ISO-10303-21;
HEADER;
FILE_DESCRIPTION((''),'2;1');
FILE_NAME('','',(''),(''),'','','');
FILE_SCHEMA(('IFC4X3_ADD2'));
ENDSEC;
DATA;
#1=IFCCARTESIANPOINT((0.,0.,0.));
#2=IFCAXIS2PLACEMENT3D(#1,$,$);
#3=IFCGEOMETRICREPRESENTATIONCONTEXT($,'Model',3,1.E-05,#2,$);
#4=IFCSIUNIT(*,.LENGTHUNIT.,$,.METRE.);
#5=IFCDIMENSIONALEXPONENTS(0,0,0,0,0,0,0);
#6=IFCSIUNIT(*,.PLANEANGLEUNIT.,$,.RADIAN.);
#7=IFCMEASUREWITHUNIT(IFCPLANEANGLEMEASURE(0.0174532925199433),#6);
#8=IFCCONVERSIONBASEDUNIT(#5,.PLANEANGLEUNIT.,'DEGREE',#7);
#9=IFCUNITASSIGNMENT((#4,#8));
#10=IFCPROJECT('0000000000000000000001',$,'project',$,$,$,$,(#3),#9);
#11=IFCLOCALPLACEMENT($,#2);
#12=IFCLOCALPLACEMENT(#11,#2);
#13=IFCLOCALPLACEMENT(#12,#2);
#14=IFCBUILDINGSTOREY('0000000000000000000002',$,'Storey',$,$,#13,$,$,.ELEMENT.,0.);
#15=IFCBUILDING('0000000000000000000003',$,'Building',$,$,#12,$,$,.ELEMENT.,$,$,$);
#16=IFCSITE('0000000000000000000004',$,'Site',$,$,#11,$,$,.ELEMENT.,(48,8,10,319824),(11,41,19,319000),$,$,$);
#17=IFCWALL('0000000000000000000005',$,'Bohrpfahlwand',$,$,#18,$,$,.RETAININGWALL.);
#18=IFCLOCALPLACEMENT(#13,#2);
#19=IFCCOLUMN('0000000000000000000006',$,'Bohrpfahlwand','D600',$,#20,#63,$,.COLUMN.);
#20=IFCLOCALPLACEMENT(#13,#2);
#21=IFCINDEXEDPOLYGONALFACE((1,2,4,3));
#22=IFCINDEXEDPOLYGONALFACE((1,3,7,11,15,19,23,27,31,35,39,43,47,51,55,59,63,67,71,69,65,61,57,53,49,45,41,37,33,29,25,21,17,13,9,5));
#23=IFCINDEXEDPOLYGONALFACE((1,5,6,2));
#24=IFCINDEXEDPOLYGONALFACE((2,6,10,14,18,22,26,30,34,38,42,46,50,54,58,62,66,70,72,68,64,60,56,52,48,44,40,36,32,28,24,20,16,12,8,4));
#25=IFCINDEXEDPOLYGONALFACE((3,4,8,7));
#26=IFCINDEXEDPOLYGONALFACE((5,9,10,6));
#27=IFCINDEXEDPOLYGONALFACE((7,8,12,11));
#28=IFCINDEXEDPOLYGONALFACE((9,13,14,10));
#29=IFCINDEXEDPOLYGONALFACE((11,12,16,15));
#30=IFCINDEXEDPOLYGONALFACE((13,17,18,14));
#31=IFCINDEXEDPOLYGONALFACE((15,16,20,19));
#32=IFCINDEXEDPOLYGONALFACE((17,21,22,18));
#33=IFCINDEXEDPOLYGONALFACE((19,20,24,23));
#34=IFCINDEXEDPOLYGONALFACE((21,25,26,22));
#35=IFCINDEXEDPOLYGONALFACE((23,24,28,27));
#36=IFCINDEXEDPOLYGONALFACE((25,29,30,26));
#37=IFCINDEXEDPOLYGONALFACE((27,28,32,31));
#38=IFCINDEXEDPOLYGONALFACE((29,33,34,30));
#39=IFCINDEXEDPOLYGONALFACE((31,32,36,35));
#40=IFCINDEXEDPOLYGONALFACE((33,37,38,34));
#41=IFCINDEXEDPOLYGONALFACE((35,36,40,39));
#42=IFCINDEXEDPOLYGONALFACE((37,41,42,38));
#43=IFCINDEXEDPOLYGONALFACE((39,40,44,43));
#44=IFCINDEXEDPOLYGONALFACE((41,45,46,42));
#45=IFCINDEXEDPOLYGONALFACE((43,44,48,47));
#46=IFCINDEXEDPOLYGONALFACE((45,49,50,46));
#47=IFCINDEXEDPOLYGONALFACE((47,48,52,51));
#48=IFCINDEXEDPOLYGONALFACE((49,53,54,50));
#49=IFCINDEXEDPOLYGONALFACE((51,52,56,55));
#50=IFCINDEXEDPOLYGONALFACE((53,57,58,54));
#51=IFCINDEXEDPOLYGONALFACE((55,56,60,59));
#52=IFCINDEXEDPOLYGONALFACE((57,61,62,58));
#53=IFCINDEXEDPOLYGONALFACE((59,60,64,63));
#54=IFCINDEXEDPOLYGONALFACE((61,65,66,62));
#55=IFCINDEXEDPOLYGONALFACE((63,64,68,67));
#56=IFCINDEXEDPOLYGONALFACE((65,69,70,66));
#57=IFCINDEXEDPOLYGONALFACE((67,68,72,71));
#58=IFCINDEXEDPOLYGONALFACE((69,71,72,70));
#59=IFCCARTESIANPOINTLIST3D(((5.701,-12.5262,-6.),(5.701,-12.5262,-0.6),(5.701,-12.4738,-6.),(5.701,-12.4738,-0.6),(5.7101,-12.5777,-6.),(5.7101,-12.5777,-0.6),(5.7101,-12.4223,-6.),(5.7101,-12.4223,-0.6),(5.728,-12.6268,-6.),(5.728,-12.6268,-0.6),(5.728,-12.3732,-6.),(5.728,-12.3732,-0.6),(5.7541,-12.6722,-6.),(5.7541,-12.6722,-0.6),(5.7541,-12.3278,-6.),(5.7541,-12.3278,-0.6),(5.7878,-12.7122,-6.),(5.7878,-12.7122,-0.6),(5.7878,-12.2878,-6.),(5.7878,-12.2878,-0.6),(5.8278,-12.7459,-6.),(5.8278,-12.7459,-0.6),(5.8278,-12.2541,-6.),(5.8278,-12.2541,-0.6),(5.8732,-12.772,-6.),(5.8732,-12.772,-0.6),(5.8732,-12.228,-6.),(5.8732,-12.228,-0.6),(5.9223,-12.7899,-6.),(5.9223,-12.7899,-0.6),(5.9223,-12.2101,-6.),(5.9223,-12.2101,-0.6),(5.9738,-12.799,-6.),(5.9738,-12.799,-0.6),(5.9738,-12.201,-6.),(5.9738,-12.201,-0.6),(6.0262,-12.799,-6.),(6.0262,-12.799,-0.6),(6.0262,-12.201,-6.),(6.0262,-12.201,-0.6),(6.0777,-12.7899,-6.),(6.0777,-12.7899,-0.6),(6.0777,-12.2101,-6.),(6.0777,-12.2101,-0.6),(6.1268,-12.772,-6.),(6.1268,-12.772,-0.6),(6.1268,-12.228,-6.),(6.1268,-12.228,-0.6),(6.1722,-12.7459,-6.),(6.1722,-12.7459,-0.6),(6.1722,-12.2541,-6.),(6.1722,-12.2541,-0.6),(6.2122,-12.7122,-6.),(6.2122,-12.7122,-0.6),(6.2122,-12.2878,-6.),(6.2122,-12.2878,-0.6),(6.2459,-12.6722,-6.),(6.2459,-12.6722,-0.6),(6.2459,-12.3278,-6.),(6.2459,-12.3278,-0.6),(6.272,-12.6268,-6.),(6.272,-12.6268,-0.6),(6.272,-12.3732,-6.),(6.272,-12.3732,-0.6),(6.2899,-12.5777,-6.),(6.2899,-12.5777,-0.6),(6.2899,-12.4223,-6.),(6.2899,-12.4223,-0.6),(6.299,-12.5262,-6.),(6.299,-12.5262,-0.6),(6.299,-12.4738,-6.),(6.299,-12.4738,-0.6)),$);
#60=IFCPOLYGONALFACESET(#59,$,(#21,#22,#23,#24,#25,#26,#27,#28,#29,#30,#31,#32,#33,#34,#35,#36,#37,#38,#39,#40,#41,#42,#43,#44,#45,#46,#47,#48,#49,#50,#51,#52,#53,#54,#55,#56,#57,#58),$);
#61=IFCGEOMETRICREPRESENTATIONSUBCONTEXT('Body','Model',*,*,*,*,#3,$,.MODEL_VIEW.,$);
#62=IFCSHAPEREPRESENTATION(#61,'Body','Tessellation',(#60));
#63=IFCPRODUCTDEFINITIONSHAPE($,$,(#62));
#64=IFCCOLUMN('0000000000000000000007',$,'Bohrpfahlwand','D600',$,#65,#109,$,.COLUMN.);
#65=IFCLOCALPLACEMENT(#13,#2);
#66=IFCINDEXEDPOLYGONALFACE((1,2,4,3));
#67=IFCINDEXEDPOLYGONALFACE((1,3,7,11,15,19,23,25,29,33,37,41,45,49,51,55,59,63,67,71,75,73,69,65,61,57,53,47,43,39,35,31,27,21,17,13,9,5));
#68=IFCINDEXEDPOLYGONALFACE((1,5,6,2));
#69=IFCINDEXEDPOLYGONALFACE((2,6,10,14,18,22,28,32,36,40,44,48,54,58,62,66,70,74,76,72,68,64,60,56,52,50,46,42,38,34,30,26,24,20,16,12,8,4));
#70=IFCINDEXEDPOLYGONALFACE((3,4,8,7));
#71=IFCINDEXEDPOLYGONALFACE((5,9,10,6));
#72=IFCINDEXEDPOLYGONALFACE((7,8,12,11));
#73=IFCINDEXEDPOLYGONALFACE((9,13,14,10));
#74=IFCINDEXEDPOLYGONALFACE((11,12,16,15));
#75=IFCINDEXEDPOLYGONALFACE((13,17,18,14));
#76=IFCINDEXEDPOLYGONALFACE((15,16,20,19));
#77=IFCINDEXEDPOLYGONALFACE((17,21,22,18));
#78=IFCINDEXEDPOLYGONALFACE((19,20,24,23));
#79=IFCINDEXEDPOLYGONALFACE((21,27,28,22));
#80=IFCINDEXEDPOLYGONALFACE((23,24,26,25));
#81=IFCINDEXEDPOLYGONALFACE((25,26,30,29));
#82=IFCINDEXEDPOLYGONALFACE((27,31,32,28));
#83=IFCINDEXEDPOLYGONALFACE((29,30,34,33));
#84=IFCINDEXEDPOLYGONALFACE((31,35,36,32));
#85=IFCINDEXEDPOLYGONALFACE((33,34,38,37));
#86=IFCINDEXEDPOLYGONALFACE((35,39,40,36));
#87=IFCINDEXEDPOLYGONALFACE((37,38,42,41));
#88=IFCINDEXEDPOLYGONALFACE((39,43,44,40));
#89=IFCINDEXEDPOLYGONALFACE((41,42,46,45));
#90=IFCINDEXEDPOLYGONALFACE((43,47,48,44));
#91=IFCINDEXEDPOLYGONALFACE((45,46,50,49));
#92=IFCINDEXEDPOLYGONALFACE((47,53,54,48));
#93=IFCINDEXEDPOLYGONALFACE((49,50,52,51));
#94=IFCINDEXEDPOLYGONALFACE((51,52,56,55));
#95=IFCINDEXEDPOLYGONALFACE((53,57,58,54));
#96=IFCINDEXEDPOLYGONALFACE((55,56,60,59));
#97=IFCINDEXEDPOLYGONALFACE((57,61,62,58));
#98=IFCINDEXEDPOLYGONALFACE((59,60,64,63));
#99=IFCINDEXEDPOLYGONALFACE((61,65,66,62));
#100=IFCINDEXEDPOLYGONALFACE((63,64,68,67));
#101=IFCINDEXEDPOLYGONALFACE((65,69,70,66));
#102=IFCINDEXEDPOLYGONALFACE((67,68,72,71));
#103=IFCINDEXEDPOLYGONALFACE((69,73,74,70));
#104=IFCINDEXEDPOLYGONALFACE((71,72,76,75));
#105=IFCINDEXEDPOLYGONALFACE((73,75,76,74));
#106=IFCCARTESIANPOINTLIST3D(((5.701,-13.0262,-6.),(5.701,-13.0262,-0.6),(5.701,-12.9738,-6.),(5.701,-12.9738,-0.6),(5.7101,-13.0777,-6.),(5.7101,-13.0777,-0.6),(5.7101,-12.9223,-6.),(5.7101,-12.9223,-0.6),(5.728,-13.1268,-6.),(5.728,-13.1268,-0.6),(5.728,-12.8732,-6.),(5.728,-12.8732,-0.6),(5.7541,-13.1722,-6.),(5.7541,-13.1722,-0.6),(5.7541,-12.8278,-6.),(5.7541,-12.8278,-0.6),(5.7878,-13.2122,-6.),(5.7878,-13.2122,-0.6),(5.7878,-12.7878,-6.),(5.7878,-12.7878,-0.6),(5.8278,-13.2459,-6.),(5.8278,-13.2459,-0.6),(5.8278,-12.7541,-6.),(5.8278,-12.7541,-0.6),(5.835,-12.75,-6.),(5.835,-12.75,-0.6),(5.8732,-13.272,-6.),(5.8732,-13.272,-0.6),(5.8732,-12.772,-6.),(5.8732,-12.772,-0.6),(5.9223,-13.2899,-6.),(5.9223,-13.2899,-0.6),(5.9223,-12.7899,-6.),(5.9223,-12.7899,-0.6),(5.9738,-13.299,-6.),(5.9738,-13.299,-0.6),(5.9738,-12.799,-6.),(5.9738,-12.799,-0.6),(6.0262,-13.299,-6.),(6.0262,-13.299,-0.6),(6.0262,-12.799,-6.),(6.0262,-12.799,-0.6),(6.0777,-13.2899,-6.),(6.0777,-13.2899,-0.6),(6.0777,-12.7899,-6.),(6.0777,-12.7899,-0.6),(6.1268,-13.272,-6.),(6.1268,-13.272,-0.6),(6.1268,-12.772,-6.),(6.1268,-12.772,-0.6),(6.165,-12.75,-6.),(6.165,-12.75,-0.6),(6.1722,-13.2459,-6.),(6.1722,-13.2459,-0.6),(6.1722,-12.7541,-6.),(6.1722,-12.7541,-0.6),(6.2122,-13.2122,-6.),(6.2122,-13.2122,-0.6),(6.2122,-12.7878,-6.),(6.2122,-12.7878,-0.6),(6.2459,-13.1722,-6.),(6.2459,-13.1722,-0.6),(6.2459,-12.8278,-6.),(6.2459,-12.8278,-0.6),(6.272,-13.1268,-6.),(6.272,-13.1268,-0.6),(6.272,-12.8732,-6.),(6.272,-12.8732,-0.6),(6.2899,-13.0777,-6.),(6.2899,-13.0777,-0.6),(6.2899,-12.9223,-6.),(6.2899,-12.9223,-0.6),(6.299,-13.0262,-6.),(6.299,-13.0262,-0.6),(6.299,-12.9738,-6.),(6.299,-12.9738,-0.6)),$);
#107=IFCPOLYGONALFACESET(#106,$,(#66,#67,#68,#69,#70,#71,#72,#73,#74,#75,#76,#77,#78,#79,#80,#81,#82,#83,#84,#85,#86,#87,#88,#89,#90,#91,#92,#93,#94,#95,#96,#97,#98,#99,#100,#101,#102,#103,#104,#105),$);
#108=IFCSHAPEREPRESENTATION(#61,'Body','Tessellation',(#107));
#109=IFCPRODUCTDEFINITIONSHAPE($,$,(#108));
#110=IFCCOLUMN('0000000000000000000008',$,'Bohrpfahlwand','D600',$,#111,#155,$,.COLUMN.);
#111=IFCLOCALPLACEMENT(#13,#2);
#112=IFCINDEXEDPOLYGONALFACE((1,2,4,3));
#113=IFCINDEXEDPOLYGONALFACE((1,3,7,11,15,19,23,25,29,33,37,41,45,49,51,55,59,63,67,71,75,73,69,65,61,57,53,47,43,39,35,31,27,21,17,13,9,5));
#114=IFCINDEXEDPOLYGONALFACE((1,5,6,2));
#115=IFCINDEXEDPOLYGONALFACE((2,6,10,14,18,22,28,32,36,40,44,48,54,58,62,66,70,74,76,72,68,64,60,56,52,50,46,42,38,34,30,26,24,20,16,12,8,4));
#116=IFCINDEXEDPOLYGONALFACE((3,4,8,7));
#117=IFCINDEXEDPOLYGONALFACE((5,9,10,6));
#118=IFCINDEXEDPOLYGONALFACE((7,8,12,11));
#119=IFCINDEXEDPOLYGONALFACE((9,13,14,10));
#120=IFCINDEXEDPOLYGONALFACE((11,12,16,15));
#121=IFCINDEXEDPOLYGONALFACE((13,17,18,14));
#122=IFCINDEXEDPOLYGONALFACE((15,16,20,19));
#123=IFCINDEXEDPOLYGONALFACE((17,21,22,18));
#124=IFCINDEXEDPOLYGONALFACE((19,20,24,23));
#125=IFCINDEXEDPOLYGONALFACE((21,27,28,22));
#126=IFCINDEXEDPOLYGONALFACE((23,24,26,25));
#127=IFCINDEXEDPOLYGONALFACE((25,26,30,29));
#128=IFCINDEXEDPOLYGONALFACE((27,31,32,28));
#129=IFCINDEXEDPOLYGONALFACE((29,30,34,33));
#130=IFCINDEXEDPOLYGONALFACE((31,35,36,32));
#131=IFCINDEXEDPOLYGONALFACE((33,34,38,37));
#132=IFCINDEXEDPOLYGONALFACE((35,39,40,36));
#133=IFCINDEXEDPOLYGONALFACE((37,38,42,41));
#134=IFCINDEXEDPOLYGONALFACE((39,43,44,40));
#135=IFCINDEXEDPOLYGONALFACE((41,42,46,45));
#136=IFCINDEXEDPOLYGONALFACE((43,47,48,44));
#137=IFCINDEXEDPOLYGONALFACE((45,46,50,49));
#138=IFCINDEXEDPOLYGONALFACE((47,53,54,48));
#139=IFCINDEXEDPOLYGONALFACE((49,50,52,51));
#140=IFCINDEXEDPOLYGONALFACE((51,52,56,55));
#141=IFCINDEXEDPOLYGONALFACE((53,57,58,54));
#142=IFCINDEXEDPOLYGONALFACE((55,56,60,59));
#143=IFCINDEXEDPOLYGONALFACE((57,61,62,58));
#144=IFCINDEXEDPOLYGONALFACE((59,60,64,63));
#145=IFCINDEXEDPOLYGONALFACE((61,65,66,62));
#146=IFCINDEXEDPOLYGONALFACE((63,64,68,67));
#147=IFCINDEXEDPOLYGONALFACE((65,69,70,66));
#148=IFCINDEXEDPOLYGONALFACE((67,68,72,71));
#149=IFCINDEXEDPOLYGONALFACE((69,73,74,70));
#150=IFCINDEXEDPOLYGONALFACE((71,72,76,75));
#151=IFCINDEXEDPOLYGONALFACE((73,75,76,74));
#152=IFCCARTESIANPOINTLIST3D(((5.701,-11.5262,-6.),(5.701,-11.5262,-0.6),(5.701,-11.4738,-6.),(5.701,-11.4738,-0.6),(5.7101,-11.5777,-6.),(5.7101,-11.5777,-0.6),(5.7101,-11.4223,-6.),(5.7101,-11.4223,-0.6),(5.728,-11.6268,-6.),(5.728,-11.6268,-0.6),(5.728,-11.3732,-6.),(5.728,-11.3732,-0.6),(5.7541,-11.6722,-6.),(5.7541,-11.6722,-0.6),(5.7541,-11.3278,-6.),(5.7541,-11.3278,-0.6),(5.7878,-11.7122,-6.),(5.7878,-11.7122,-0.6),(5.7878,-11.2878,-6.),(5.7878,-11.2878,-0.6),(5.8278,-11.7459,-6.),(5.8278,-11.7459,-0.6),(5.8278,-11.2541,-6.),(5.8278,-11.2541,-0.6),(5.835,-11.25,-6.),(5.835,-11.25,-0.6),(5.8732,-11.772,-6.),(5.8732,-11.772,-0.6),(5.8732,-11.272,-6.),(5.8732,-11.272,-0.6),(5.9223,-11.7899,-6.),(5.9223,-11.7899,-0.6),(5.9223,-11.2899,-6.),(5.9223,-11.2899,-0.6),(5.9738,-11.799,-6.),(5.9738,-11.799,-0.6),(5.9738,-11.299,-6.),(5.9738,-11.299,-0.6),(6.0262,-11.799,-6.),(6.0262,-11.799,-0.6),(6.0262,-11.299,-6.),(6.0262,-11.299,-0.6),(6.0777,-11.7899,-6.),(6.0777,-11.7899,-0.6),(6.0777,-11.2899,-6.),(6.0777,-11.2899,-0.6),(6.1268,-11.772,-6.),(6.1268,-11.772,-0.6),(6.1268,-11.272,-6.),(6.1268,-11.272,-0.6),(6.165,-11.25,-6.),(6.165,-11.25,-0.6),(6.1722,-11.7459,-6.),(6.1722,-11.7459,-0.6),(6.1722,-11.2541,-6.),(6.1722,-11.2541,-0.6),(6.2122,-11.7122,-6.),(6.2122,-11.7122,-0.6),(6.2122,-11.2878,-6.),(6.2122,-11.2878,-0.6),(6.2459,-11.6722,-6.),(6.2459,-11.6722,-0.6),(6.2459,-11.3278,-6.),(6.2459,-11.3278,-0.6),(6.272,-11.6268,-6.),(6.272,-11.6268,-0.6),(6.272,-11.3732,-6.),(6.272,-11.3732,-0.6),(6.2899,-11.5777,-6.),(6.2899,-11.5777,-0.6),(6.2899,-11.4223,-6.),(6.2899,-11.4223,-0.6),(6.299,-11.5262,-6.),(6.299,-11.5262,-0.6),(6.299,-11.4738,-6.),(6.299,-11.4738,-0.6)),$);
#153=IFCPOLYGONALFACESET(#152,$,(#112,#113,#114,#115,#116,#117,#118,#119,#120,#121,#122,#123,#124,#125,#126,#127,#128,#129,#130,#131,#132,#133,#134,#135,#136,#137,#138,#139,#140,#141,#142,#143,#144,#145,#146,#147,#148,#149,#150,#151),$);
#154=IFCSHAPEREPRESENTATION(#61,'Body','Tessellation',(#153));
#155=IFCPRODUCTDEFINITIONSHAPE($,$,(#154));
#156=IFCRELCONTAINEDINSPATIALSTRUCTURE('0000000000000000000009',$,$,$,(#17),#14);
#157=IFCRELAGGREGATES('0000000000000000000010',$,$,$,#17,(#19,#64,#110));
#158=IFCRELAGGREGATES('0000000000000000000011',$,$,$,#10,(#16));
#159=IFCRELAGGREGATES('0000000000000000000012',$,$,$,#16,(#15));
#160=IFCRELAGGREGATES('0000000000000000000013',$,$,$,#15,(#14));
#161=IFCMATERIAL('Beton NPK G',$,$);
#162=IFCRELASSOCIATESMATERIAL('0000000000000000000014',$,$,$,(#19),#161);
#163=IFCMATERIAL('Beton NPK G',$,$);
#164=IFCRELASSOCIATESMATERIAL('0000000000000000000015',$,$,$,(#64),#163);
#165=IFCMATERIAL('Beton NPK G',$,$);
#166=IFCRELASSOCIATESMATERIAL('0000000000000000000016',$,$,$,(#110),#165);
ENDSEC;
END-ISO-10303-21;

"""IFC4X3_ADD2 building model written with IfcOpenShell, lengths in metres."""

from ifc_helpers import new_model, entity, si_unit, converted_unit, frame, origin, origin_with_axes, place, context, subcontext, project, spatial, polyline, outline, extrude, material, element, aggregate, save


model = new_model("IFC4X3_ADD2")

# Units and contexts
model_context = context("Model", 3, precision=1e-05, world=origin())
body_context = subcontext(model_context, "Body", "Model", "MODEL_VIEW")
ifc_project = project(units=[si_unit("LENGTHUNIT", "METRE"), converted_unit("PLANEANGLEUNIT", "DEGREE", entity("IfcPlaneAngleMeasure", 0.0174532925199433), si_unit("PLANEANGLEUNIT", "RADIAN"), dimensions=[0, 0, 0, 0, 0, 0, 0])], contexts=[model_context])

# Site, building, storey
site_placement = place(None, origin())
site = spatial("IfcSite", under=ifc_project, at=site_placement, Name="Site", CompositionType="ELEMENT", RefLatitude=(48, 8, 10, 319824), RefLongitude=(11, 41, 19, 319000))
building_placement = place(site_placement, origin())
building = spatial("IfcBuilding", under=site, at=building_placement, Name="Building", CompositionType="ELEMENT")
storey_placement = place(building_placement, origin())
storey = spatial("IfcBuildingStorey", under=building, at=storey_placement, Name="Storey", CompositionType="ELEMENT", Elevation=0.0)

# Wall, columns
wall_1_placement = place(storey_placement, origin())
wall_1 = element("IfcWall", 1, at=wall_1_placement, inside=storey, Name="Bohrpfahlwand", PredefinedType="RETAININGWALL")
ifc_material_1 = material(Name="Beton NPK G")
column_1_placement = place(wall_1_placement, frame((5.701, -12.799, -6.0)))
column_1 = element("IfcColumn", 2, at=column_1_placement, material=ifc_material_1, Name="Bohrpfahlwand", Description="D600", PredefinedType="COLUMN", context=body_context, shape_type="SweptSolid", body=[
    extrude(outline(polyline([(0.3252, 0.598), (0.2728, 0.598), (0.2213, 0.5889), (0.1722, 0.571), (0.1268, 0.5449), (0.0868, 0.5112), (0.0531, 0.4712), (0.027, 0.4258), (0.0091, 0.3767), (0.0, 0.3252), (0.0, 0.2728), (0.0091, 0.2213), (0.027, 0.1722), (0.0531, 0.1268), (0.0868, 0.0868), (0.1268, 0.0531), (0.1722, 0.027), (0.2213, 0.0091), (0.2728, 0.0), (0.3252, 0.0), (0.3767, 0.0091), (0.4258, 0.027), (0.4712, 0.0531), (0.5112, 0.0868), (0.5449, 0.1268), (0.571, 0.1722), (0.5889, 0.2213), (0.598, 0.2728), (0.598, 0.3252), (0.5889, 0.3767), (0.571, 0.4258), (0.5449, 0.4712), (0.5112, 0.5112), (0.4712, 0.5449), (0.4258, 0.571), (0.3767, 0.5889), (0.3252, 0.598)])), origin_with_axes(), (0.0, 0.0, 1.0), 5.4),
])
ifc_material_2 = material(Name="Beton NPK G")
column_2_placement = place(wall_1_placement, frame((5.701, -13.299, -6.0)))
column_2 = element("IfcColumn", 3, at=column_2_placement, material=ifc_material_2, Name="Bohrpfahlwand", Description="D600", PredefinedType="COLUMN", context=body_context, shape_type="SweptSolid", body=[
    extrude(outline(polyline([(0.464, 0.549), (0.4258, 0.527), (0.3767, 0.5091), (0.3252, 0.5), (0.2728, 0.5), (0.2213, 0.5091), (0.1722, 0.527), (0.134, 0.549), (0.1268, 0.5449), (0.0868, 0.5112), (0.0531, 0.4712), (0.027, 0.4258), (0.0091, 0.3767), (0.0, 0.3252), (0.0, 0.2728), (0.0091, 0.2213), (0.027, 0.1722), (0.0531, 0.1268), (0.0868, 0.0868), (0.1268, 0.0531), (0.1722, 0.027), (0.2213, 0.0091), (0.2728, 0.0), (0.3252, 0.0), (0.3767, 0.0091), (0.4258, 0.027), (0.4712, 0.0531), (0.5112, 0.0868), (0.5449, 0.1268), (0.571, 0.1722), (0.5889, 0.2213), (0.598, 0.2728), (0.598, 0.3252), (0.5889, 0.3767), (0.571, 0.4258), (0.5449, 0.4712), (0.5112, 0.5112), (0.4712, 0.5449), (0.464, 0.549)])), origin_with_axes(), (0.0, 0.0, 1.0), 5.4),
])
ifc_material_3 = material(Name="Beton NPK G")
column_3_placement = place(wall_1_placement, frame((5.701, -11.799, -6.0)))
column_3 = element("IfcColumn", 4, at=column_3_placement, material=ifc_material_3, Name="Bohrpfahlwand", Description="D600", PredefinedType="COLUMN", context=body_context, shape_type="SweptSolid", body=[
    extrude(outline(polyline([(0.464, 0.549), (0.4258, 0.527), (0.3767, 0.5091), (0.3252, 0.5), (0.2728, 0.5), (0.2213, 0.5091), (0.1722, 0.527), (0.134, 0.549), (0.1268, 0.5449), (0.0868, 0.5112), (0.0531, 0.4712), (0.027, 0.4258), (0.0091, 0.3767), (0.0, 0.3252), (0.0, 0.2728), (0.0091, 0.2213), (0.027, 0.1722), (0.0531, 0.1268), (0.0868, 0.0868), (0.1268, 0.0531), (0.1722, 0.027), (0.2213, 0.0091), (0.2728, 0.0), (0.3252, 0.0), (0.3767, 0.0091), (0.4258, 0.027), (0.4712, 0.0531), (0.5112, 0.0868), (0.5449, 0.1268), (0.571, 0.1722), (0.5889, 0.2213), (0.598, 0.2728), (0.598, 0.3252), (0.5889, 0.3767), (0.571, 0.4258), (0.5449, 0.4712), (0.5112, 0.5112), (0.4712, 0.5449), (0.464, 0.549)])), origin_with_axes(), (0.0, 0.0, 1.0), 5.4),
])
aggregate(wall_1, [column_1, column_2, column_3])

save(model, "model.ifc")
